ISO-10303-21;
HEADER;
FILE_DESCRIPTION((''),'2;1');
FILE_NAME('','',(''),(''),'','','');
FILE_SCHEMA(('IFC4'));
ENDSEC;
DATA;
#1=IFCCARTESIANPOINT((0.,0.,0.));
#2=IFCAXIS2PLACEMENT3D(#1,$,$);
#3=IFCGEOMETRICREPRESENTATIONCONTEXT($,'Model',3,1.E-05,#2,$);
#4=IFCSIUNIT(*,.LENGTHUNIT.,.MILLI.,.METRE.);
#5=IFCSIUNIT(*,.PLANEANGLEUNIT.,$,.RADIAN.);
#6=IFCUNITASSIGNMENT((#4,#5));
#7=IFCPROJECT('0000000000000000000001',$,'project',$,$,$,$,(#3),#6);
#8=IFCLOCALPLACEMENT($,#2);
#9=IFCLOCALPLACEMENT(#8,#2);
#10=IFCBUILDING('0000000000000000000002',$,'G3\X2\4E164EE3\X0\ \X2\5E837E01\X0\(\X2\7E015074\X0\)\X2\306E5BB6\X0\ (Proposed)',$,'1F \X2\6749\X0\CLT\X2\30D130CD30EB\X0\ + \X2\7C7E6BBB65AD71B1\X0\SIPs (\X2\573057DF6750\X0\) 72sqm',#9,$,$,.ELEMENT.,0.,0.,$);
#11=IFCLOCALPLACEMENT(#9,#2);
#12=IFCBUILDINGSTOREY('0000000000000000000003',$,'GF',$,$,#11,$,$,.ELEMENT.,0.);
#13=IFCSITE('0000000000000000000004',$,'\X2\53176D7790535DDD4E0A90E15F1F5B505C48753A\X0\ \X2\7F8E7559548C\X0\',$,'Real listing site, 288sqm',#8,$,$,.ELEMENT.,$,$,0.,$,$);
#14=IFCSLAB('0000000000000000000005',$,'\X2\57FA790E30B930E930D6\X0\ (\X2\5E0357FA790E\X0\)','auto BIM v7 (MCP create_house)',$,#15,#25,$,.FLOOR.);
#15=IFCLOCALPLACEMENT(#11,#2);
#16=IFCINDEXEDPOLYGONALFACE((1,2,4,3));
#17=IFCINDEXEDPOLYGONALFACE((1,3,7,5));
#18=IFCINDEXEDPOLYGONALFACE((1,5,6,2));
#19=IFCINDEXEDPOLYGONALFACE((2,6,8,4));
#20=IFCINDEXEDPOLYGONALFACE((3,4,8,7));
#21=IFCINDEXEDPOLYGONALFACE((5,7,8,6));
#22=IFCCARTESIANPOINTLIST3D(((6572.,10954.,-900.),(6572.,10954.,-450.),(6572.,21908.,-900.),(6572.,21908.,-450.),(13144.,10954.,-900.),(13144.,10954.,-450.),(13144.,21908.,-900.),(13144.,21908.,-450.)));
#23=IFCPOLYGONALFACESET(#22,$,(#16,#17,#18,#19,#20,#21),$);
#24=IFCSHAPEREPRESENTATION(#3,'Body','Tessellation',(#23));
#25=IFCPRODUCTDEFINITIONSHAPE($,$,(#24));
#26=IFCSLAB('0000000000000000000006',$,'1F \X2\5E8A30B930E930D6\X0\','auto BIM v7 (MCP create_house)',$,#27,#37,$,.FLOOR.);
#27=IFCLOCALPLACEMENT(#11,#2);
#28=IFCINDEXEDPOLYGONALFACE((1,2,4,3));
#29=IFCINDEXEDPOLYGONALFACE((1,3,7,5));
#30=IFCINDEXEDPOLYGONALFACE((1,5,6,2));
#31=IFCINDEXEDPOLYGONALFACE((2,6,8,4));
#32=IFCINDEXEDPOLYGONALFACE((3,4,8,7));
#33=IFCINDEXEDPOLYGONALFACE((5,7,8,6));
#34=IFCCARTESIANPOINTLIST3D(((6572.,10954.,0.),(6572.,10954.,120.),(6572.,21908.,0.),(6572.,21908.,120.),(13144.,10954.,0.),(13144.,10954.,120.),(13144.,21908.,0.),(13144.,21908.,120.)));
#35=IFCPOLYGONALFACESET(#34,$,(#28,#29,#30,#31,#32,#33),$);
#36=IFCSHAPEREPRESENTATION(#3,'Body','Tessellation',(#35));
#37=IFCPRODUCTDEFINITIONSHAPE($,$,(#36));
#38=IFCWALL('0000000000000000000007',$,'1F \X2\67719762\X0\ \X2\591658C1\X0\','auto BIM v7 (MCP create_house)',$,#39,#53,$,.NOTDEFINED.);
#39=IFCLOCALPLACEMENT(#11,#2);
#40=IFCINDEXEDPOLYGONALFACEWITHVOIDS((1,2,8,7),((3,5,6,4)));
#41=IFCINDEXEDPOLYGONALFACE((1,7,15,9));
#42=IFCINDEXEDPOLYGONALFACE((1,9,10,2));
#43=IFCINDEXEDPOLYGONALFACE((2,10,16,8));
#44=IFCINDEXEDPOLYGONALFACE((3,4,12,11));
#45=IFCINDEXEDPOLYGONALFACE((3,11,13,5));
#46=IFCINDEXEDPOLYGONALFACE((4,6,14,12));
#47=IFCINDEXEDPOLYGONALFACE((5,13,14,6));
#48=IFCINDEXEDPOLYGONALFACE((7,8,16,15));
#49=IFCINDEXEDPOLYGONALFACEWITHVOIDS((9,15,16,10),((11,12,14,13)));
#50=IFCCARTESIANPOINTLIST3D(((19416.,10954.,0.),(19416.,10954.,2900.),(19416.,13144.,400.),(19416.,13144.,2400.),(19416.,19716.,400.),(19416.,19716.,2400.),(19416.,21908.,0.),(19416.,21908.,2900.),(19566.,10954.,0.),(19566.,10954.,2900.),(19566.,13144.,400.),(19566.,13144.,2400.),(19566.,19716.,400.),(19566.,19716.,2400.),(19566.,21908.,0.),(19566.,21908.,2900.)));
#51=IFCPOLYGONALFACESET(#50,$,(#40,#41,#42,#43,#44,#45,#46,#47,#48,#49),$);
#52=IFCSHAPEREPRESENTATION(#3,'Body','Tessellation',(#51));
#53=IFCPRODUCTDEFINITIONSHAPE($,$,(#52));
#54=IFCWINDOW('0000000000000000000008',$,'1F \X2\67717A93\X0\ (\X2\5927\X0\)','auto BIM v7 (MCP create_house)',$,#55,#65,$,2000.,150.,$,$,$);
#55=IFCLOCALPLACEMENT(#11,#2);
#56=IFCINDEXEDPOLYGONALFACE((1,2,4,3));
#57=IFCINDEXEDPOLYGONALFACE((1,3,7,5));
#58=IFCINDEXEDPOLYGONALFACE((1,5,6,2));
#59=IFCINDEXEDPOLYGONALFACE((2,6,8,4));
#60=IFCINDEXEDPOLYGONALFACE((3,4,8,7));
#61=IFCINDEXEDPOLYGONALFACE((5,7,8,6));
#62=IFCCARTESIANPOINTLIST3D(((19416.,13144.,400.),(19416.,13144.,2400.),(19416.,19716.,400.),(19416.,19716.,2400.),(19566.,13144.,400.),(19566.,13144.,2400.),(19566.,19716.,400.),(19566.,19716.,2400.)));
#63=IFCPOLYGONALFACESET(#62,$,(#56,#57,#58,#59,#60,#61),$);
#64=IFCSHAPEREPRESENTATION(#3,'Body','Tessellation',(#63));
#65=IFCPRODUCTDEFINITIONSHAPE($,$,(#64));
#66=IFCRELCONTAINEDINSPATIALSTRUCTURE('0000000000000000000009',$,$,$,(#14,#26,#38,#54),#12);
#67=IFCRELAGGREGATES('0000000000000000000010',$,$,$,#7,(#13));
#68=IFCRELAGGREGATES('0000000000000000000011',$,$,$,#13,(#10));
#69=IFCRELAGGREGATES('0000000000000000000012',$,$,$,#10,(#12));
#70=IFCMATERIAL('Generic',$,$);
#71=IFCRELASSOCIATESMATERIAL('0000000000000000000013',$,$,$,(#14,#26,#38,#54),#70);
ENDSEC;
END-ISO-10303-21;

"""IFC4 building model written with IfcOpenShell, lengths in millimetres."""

from ifc_helpers import new_model, si_unit, frame, frame_2d, origin, place, context, project, spatial, rectangle, extrude, material, element, fill, save


model = new_model("IFC4")

# Units and contexts
model_context = context("Model", 3, precision=1e-05, world=origin())
ifc_project = project(units=[si_unit("LENGTHUNIT", "METRE", prefix="MILLI"), si_unit("PLANEANGLEUNIT", "RADIAN")], contexts=[model_context])

# Site, building, storey
site_placement = place(None, origin())
site = spatial("IfcSite", under=ifc_project, at=site_placement, Name="北海道川上郡弟子屈町 美留和", ObjectType="Real listing site, 288sqm", CompositionType="ELEMENT", RefElevation=0.0)
building_placement = place(site_placement, origin())
building = spatial("IfcBuilding", under=site, at=building_placement, Name="G3世代 広縁(縁側)の家 (Proposed)", ObjectType="1F 杉CLTパネル + 籾殻断熱SIPs (地域材) 72sqm", CompositionType="ELEMENT", ElevationOfRefHeight=0.0, ElevationOfTerrain=0.0)
storey_placement = place(building_placement, origin())
storey = spatial("IfcBuildingStorey", under=building, at=storey_placement, Name="GF", CompositionType="ELEMENT", Elevation=0.0)

# Slabs
ifc_material = material(Name="Generic")
slab_1_placement = place(storey_placement, frame((3286.0, 5477.0, -450.0)))
element("IfcSlab", 1, at=slab_1_placement, inside=storey, material=ifc_material, Name="基礎スラブ (布基礎)", Description="auto BIM v7 (MCP create_house)", PredefinedType="FLOOR", context=model_context, shape_type="SweptSolid", body=[
    extrude(rectangle(XDim=6572.0, YDim=10954.0, at=frame_2d((3286.0, 5477.0))), frame((3286.0, 5477.0, -450.0)), (0.0, 0.0, 1.0), 450.0),
])
slab_2_placement = place(storey_placement, frame((3286.0, 5477.0, 0.0)))
element("IfcSlab", 2, at=slab_2_placement, inside=storey, material=ifc_material, Name="1F 床スラブ", Description="auto BIM v7 (MCP create_house)", PredefinedType="FLOOR", context=model_context, shape_type="SweptSolid", body=[
    extrude(rectangle(XDim=6572.0, YDim=10954.0, at=frame_2d((3286.0, 5477.0))), frame((3286.0, 5477.0, 0.0)), (0.0, 0.0, 1.0), 120.0),
])

# Wall, opening, window
wall_1_placement = place(storey_placement, frame((9708.0, 5477.0, 0.0)))
wall_1 = element("IfcWall", 3, at=wall_1_placement, inside=storey, material=ifc_material, Name="1F 東面 外壁", Description="auto BIM v7 (MCP create_house)", PredefinedType="NOTDEFINED", context=model_context, shape_type="SweptSolid", body=[
    extrude(rectangle(XDim=150.0, YDim=10954.0, at=frame_2d((75.0, 5477.0))), frame((9708.0, 5477.0, 0.0)), (0.0, 0.0, 1.0), 2900.0),
])
opening_1_placement = place(storey_placement, frame((9708.0, 6572.0, 200.0)))
opening_1 = element("IfcOpeningElement", 4, at=opening_1_placement, cuts=wall_1, PredefinedType="NOTDEFINED", context=model_context, shape_type="SweptSolid", body=[
    extrude(rectangle(XDim=150.0, YDim=6572.0, at=frame_2d((75.0, 3286.0))), frame((9708.0, 6572.0, 200.0)), (0.0, 0.0, 1.0), 2000.0),
])
window_1_placement = place(storey_placement, frame((9708.0, 6572.0, 200.0)))
window_1 = element("IfcWindow", 5, at=window_1_placement, inside=storey, material=ifc_material, Name="1F 東窓 (大)", Description="auto BIM v7 (MCP create_house)", OverallHeight=2000.0, OverallWidth=150.0, context=model_context, shape_type="SweptSolid", body=[
    extrude(rectangle(XDim=150.0, YDim=6572.0, at=frame_2d((75.0, 3286.0))), frame((9708.0, 6572.0, 200.0)), (0.0, 0.0, 1.0), 2000.0),
])
fill(opening_1, window_1)

save(model, "model.ifc")
